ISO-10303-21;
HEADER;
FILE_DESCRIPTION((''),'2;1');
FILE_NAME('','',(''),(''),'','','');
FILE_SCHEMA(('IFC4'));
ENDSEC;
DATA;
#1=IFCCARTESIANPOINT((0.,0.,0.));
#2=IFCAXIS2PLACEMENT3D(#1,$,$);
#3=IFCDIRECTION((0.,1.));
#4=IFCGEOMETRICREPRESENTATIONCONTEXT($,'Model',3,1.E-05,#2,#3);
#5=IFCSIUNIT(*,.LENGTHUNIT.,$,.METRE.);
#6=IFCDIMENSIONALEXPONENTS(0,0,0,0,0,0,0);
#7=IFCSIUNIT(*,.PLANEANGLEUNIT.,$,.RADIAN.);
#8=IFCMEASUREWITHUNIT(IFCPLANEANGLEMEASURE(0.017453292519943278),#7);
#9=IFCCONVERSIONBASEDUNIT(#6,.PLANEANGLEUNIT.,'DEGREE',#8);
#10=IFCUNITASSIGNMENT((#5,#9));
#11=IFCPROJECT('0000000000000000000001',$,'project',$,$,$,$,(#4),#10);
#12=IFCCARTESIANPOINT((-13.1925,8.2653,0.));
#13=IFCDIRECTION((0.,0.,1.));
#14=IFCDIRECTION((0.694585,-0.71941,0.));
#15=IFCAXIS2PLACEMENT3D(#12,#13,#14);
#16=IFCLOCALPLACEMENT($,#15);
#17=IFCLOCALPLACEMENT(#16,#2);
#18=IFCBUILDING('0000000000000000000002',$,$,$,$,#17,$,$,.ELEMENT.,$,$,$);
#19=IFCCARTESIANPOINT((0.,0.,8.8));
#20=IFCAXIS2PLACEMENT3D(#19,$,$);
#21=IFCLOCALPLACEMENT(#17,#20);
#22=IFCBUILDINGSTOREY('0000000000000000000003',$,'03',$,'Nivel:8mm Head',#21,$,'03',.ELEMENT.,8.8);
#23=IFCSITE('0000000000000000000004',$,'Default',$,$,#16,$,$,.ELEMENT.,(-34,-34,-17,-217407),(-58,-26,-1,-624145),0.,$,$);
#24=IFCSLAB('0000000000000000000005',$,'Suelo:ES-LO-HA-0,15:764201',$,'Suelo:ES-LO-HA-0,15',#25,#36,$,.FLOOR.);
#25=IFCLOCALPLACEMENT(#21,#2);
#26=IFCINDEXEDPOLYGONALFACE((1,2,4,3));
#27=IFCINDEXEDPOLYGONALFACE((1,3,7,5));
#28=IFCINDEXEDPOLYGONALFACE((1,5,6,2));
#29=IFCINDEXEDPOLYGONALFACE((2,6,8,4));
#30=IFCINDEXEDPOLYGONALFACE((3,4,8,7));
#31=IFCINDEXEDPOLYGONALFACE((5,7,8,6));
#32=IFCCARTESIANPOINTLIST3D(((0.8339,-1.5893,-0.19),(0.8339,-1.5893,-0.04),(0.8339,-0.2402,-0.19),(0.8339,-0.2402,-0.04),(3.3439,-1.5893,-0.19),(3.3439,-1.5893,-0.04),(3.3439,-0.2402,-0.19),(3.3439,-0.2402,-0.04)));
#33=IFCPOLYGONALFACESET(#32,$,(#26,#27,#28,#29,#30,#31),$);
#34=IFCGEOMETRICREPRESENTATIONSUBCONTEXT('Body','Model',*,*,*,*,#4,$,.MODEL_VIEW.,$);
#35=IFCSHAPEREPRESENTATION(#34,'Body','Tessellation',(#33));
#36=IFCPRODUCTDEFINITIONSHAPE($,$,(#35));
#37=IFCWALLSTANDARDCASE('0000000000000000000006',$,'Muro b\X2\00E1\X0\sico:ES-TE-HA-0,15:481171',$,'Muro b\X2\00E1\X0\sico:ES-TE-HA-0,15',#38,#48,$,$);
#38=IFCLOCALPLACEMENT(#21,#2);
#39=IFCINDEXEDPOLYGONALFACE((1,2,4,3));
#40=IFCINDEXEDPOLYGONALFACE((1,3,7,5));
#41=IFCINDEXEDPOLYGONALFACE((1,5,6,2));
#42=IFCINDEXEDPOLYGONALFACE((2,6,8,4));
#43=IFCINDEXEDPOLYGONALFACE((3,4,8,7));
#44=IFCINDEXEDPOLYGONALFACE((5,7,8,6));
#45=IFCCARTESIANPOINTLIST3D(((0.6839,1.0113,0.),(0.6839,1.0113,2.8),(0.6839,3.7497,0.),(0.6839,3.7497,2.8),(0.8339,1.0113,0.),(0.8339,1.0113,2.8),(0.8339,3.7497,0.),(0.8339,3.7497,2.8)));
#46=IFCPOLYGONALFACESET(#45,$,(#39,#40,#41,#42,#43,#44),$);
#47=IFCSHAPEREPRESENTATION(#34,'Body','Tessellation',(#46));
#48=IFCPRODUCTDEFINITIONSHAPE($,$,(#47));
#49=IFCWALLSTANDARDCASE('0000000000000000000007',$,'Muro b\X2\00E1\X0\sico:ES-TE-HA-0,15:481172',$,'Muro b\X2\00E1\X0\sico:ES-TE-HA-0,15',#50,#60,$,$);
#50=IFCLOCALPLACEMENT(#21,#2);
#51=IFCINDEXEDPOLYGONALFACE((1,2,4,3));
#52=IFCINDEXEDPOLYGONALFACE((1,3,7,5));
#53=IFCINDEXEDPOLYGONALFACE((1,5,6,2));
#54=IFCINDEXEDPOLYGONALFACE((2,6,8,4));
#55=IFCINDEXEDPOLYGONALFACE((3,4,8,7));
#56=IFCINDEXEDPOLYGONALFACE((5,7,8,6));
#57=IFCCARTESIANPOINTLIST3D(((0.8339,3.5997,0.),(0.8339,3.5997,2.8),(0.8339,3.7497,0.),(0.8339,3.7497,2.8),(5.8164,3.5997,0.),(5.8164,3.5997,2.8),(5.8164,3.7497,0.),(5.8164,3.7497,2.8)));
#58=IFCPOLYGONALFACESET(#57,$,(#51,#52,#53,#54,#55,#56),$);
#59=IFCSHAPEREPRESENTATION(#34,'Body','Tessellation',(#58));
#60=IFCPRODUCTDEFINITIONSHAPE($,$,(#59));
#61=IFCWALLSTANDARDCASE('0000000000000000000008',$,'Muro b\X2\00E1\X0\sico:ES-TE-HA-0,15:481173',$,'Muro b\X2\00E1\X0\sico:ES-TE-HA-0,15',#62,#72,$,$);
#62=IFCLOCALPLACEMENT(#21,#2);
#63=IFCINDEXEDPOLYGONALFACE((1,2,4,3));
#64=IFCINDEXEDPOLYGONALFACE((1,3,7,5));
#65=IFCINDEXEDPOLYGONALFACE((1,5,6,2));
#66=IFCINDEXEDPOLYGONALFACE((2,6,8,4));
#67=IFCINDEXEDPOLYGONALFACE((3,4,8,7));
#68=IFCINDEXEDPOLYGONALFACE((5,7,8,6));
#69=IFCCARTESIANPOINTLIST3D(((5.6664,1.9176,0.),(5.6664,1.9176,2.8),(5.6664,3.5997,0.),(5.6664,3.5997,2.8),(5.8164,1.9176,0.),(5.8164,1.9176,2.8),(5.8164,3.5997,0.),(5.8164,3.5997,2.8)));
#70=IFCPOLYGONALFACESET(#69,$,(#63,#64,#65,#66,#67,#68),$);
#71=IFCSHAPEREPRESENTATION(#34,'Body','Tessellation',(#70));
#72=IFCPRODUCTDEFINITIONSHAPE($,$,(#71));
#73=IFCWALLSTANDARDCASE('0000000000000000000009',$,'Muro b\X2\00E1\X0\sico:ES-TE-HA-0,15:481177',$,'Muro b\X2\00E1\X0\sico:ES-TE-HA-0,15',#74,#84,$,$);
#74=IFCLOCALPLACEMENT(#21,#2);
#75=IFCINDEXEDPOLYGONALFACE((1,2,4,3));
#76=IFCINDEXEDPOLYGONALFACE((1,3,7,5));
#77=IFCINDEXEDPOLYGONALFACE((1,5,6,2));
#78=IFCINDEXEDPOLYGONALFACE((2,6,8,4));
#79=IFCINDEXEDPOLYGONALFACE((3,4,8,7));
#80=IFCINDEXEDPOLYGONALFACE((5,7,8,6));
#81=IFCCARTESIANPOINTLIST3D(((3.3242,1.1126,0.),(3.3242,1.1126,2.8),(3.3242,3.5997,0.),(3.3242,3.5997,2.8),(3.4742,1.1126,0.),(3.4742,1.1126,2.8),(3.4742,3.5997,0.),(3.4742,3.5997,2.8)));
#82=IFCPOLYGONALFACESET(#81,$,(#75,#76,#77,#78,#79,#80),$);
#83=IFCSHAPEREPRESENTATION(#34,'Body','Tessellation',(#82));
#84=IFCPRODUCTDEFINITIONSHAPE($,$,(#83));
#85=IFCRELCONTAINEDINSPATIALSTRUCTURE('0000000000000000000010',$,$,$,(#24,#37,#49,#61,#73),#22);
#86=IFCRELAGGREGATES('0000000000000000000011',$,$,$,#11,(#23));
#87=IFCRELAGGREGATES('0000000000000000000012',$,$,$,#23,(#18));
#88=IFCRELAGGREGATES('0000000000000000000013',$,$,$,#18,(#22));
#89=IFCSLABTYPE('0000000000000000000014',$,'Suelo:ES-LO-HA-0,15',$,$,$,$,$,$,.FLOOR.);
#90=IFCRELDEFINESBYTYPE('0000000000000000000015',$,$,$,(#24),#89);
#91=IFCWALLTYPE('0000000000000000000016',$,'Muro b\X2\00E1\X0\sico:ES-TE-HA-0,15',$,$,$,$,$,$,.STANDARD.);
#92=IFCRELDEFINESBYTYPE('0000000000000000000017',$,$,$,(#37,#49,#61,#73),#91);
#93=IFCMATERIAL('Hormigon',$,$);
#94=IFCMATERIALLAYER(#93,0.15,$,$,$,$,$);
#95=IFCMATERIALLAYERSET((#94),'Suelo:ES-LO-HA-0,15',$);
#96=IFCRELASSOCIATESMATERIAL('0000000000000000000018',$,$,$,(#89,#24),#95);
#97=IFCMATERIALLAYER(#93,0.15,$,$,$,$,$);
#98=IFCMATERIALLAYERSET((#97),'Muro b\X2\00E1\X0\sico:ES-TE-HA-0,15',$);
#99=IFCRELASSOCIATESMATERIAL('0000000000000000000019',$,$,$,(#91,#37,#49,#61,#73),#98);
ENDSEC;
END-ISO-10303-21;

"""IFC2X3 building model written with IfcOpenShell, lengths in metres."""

from ifc_helpers import new_model, entity, si_unit, converted_unit, direction, frame, frame_2d, origin, origin_2d_with_axis, place, context, subcontext, project, spatial, rectangle, extrude, material, layer, layer_set, layer_usage, type_object, element, save


model = new_model("IFC2X3")

# Units and contexts
model_context = context("Model", 3, precision=1e-05, world=origin(), true_north=direction((0.0, 1.0)))
body_context = subcontext(model_context, "Body", "Model", "MODEL_VIEW")
ifc_project = project(units=[si_unit("LENGTHUNIT", "METRE"), converted_unit("PLANEANGLEUNIT", "DEGREE", entity("IfcPlaneAngleMeasure", 0.017453292519943278), si_unit("PLANEANGLEUNIT", "RADIAN"), dimensions=[0, 0, 0, 0, 0, 0, 0])], contexts=[model_context])

# Site, building, storey
site_placement = place(None, frame((-13.1925, 8.2653, 0.0), z_axis=(0.0, 0.0, 1.0), x_axis=(0.694585, -0.71941, 0.0)))
site = spatial("IfcSite", under=ifc_project, at=site_placement, Name="Default", CompositionType="ELEMENT", RefLatitude=(-34, -34, -17, -217407), RefLongitude=(-58, -26, -1, -624145), RefElevation=0.0)
building_placement = place(site_placement, origin())
building = spatial("IfcBuilding", under=site, at=building_placement, CompositionType="ELEMENT")
storey_placement = place(building_placement, frame((0.0, 0.0, 8.8)))
storey = spatial("IfcBuildingStorey", under=building, at=storey_placement, Name="03", ObjectType="Nivel:8mm Head", LongName="03", CompositionType="ELEMENT", Elevation=8.8)

# Slab
ifc_material_1 = material(Name="Hormigon")
ifc_layer_1 = layer(ifc_material_1, 0.15)
ifc_layer_set_1 = layer_set([ifc_layer_1], Name="Suelo:ES-LO-HA-0,15")
ifc_layer_usage_1 = layer_usage(ifc_layer_set_1, "AXIS3", "POSITIVE", 0.0)
slab_type_1 = type_object("IfcSlabType", Name="Suelo:ES-LO-HA-0,15", PredefinedType="FLOOR", material=ifc_layer_set_1)
slab_1_placement = place(storey_placement, origin())
element("IfcSlab", 1, at=slab_1_placement, inside=storey, type_object=slab_type_1, material=ifc_layer_usage_1, Name="Suelo:ES-LO-HA-0,15:764201", ObjectType="Suelo:ES-LO-HA-0,15", PredefinedType="FLOOR", context=body_context, shape_type="SweptSolid", body=[
    extrude(rectangle(XDim=1.3491, YDim=2.51, at=origin_2d_with_axis()), frame((2.0889, -0.9147, -0.04), z_axis=(0.0, 0.0, -1.0), x_axis=(0.0, 1.0, 0.0)), (0.0, 0.0, 1.0), 0.15),
])

# Walls
ifc_layer_2 = layer(ifc_material_1, 0.15)
ifc_layer_set_2 = layer_set([ifc_layer_2], Name="Muro básico:ES-TE-HA-0,15")
ifc_layer_usage_2 = layer_usage(ifc_layer_set_2, "AXIS2", "NEGATIVE", 0.075)
wall_type = type_object("IfcWallType", Name="Muro básico:ES-TE-HA-0,15", PredefinedType="STANDARD", material=ifc_layer_set_2)
wall_1_placement = place(storey_placement, frame((0.7589, 1.0113, 0.0), z_axis=(0.0, 0.0, 1.0), x_axis=(0.0, 1.0, 0.0)))
element("IfcWallStandardCase", 2, at=wall_1_placement, inside=storey, type_object=wall_type, material=ifc_layer_usage_2, Name="Muro básico:ES-TE-HA-0,15:481171", ObjectType="Muro básico:ES-TE-HA-0,15", context=body_context, shape_type="SweptSolid", body=[
    extrude(rectangle(XDim=2.7384, YDim=0.15, at=frame_2d((1.3692, 0.0), x_axis=(-1.0, 0.0))), origin(), (0.0, 0.0, 1.0), 2.8),
])
ifc_layer_usage_3 = layer_usage(ifc_layer_set_2, "AXIS2", "NEGATIVE", 0.075)
wall_2_placement = place(storey_placement, frame((0.8339, 3.6747, 0.0)))
element("IfcWallStandardCase", 3, at=wall_2_placement, inside=storey, type_object=wall_type, material=ifc_layer_usage_3, Name="Muro básico:ES-TE-HA-0,15:481172", ObjectType="Muro básico:ES-TE-HA-0,15", context=body_context, shape_type="SweptSolid", body=[
    extrude(rectangle(XDim=4.9825, YDim=0.15, at=frame_2d((2.4912, 0.0), x_axis=(-1.0, 0.0))), origin(), (0.0, 0.0, 1.0), 2.8),
])
ifc_layer_usage_4 = layer_usage(ifc_layer_set_2, "AXIS2", "NEGATIVE", 0.075)
wall_3_placement = place(storey_placement, frame((5.7414, 1.9176, 0.0), z_axis=(0.0, 0.0, 1.0), x_axis=(0.0, 1.0, 0.0)))
element("IfcWallStandardCase", 4, at=wall_3_placement, inside=storey, type_object=wall_type, material=ifc_layer_usage_4, Name="Muro básico:ES-TE-HA-0,15:481173", ObjectType="Muro básico:ES-TE-HA-0,15", context=body_context, shape_type="SweptSolid", body=[
    extrude(rectangle(XDim=1.682, YDim=0.15, at=frame_2d((0.841, 0.0), x_axis=(-1.0, 0.0))), origin(), (0.0, 0.0, 1.0), 2.8),
])
ifc_layer_usage_5 = layer_usage(ifc_layer_set_2, "AXIS2", "NEGATIVE", 0.075)
wall_4_placement = place(storey_placement, frame((3.3992, 3.5997, 0.0), z_axis=(0.0, 0.0, 1.0), x_axis=(0.0, -1.0, 0.0)))
element("IfcWallStandardCase", 5, at=wall_4_placement, inside=storey, type_object=wall_type, material=ifc_layer_usage_5, Name="Muro básico:ES-TE-HA-0,15:481177", ObjectType="Muro básico:ES-TE-HA-0,15", context=body_context, shape_type="SweptSolid", body=[
    extrude(rectangle(XDim=2.487, YDim=0.15, at=frame_2d((1.2435, 0.0), x_axis=(-1.0, 0.0))), origin(), (0.0, 0.0, 1.0), 2.8),
])

save(model, "model.ifc")
